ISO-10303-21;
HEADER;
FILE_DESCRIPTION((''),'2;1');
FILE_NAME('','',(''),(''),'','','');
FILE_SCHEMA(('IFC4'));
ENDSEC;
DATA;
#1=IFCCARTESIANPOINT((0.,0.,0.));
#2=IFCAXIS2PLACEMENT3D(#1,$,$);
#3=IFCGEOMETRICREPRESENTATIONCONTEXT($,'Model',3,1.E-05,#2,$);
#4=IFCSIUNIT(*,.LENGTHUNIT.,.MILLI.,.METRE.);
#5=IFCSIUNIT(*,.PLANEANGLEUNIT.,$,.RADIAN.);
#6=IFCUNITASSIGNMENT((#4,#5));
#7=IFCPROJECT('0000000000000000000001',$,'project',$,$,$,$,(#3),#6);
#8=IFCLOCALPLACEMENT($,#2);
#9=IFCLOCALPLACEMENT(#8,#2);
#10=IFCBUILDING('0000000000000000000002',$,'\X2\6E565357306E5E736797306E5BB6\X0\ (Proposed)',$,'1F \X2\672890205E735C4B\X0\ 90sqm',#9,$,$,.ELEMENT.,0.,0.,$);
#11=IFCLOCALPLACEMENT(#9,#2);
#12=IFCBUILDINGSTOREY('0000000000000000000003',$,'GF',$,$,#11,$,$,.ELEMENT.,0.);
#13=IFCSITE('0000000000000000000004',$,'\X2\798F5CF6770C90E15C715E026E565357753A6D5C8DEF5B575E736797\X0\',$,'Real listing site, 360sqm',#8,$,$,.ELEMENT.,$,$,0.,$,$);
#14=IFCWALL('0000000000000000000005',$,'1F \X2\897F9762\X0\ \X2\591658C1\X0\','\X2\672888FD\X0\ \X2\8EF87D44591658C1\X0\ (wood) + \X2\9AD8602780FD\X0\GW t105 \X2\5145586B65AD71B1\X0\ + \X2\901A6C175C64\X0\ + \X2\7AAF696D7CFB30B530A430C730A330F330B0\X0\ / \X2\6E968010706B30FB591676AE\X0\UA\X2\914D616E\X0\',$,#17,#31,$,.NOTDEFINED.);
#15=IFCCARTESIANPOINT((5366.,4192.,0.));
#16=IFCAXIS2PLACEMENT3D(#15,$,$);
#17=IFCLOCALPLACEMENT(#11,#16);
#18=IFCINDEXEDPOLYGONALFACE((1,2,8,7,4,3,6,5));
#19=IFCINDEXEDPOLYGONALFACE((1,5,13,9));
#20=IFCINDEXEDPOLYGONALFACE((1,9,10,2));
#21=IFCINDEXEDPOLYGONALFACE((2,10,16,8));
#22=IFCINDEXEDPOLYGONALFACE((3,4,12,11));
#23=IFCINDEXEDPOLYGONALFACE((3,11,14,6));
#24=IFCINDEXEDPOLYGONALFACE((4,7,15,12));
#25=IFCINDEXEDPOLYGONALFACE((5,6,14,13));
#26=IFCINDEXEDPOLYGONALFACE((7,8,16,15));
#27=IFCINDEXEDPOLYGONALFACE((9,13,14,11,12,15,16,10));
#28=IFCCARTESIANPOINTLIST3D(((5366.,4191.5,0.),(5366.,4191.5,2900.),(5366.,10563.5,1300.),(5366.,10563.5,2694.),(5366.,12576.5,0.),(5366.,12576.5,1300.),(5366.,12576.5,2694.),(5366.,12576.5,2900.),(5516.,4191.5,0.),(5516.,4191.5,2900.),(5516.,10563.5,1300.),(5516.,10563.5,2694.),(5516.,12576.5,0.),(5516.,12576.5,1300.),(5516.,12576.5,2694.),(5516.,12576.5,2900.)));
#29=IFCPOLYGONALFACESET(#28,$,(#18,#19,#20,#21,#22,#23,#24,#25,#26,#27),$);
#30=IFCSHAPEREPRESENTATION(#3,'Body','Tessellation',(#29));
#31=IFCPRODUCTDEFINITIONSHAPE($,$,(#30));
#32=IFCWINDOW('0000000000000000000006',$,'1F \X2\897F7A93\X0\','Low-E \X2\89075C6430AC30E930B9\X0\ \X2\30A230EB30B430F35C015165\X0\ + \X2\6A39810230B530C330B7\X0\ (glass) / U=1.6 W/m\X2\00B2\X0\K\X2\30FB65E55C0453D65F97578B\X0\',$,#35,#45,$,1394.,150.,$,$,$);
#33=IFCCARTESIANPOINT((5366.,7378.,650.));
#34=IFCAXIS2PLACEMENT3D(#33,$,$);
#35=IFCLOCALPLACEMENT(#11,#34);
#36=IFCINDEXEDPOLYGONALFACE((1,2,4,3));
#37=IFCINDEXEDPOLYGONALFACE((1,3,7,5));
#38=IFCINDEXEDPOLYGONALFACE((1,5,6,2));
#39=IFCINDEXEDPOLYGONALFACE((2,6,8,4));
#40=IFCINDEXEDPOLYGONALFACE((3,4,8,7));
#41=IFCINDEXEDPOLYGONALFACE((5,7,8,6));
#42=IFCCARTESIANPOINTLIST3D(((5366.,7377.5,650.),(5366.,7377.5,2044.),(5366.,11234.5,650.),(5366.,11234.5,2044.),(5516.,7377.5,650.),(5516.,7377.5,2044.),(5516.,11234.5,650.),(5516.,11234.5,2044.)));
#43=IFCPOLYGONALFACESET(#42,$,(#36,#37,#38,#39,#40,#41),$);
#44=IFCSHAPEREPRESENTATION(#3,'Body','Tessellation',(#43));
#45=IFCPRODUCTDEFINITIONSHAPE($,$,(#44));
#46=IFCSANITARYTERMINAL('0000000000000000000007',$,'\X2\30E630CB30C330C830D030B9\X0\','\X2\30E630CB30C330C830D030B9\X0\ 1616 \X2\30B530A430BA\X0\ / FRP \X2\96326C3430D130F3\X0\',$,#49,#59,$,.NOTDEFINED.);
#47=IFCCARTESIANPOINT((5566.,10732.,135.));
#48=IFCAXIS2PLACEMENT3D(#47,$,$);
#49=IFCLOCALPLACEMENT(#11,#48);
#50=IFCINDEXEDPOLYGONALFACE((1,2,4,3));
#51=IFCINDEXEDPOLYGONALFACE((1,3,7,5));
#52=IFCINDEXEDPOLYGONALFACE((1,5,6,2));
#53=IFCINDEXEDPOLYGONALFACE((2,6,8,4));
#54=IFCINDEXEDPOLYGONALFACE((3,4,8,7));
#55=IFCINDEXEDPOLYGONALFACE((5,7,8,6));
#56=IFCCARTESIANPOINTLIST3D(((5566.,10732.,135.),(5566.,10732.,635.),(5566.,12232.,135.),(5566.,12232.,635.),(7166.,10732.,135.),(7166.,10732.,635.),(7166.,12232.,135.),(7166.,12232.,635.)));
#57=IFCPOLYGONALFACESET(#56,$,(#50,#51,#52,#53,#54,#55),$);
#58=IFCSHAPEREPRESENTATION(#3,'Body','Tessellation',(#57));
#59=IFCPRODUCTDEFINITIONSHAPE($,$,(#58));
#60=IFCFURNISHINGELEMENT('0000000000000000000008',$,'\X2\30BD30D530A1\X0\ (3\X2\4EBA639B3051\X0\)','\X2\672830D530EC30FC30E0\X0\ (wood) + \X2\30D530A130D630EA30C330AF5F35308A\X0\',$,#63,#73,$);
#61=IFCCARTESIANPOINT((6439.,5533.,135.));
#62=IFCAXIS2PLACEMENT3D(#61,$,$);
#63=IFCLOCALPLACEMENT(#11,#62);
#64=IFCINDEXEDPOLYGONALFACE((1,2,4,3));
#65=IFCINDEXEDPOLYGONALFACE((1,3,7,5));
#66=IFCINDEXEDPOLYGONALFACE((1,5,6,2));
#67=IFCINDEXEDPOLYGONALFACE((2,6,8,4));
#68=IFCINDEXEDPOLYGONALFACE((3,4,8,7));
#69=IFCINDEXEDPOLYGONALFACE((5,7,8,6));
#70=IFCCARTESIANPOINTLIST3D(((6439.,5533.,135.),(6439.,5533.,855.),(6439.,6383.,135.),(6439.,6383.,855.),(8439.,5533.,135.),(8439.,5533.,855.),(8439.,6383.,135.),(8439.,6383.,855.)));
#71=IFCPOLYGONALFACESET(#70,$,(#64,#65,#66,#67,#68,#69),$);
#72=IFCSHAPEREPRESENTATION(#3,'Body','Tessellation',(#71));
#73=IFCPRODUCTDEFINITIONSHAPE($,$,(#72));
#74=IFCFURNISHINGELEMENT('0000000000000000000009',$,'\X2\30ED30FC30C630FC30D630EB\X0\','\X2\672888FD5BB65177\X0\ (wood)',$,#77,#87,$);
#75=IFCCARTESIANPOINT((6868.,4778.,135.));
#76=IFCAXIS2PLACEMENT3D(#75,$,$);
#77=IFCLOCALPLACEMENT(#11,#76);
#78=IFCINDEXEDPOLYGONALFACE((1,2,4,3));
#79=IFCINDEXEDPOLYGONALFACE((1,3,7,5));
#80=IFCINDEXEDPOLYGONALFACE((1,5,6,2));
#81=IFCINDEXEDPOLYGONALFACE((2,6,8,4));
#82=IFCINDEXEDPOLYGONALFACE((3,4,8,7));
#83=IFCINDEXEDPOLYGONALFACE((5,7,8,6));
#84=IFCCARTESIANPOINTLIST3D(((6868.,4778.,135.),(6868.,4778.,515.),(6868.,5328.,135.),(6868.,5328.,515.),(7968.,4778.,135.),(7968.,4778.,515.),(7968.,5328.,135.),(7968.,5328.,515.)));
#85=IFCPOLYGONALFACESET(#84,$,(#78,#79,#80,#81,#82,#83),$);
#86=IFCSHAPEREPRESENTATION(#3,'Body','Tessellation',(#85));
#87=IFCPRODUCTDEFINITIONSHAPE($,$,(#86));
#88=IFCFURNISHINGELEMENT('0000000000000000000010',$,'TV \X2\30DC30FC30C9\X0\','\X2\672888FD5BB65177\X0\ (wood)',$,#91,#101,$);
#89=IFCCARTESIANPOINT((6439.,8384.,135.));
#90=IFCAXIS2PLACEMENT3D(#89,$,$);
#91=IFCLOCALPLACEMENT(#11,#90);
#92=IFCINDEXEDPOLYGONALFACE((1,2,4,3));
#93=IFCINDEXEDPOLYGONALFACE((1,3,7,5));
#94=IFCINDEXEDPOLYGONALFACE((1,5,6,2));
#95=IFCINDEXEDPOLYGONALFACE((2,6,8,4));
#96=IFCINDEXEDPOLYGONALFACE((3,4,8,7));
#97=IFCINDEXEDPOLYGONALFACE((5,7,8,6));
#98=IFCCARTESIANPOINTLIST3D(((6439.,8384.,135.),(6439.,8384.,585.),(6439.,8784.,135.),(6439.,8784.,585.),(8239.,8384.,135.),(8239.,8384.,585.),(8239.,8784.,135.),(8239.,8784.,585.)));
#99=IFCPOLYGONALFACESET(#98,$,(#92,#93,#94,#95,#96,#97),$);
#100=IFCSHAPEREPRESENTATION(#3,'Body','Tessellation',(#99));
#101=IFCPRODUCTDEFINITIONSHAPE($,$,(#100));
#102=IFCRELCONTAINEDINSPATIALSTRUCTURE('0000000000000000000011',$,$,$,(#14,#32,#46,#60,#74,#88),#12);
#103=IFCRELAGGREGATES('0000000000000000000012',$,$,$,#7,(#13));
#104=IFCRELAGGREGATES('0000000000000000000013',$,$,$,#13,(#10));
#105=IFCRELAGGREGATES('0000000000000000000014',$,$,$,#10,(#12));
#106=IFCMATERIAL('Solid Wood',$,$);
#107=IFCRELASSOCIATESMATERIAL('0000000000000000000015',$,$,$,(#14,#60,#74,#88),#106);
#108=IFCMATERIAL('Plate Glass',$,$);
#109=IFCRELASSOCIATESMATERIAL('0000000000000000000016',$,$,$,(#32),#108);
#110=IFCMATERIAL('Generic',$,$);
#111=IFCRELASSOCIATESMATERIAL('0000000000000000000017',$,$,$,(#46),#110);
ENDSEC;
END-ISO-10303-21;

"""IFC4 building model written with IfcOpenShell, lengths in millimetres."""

from ifc_helpers import new_model, si_unit, frame, frame_2d, origin, place, context, project, spatial, rectangle, extrude, material, element, fill, save


model = new_model("IFC4")

# Units and contexts
model_context = context("Model", 3, precision=1e-05, world=origin())
ifc_project = project(units=[si_unit("LENGTHUNIT", "METRE", prefix="MILLI"), si_unit("PLANEANGLEUNIT", "RADIAN")], contexts=[model_context])

# Site, building, storey
site_placement = place(None, origin())
site = spatial("IfcSite", under=ifc_project, at=site_placement, Name="福島県郡山市湖南町浜路字平林", ObjectType="Real listing site, 360sqm", CompositionType="ELEMENT", RefElevation=0.0)
building_placement = place(site_placement, origin())
building = spatial("IfcBuilding", under=site, at=building_placement, Name="湖南の平林の家 (Proposed)", ObjectType="1F 木造平屋 90sqm", CompositionType="ELEMENT", ElevationOfRefHeight=0.0, ElevationOfTerrain=0.0)
storey_placement = place(building_placement, origin())
storey = spatial("IfcBuildingStorey", under=building, at=storey_placement, Name="GF", CompositionType="ELEMENT", Elevation=0.0)

# Shared definitions
ifc_material_1 = material(Name="Solid Wood")

# Shared definitions
ifc_material_2 = material(Name="Plate Glass")

# Wall, opening, window
wall_1_placement = place(storey_placement, frame((5366.0, 4192.0, 0.0)))
wall_1 = element("IfcWall", 1, at=wall_1_placement, inside=storey, material=ifc_material_1, Name="1F 西面 外壁", Description="木製 軸組外壁 (wood) + 高性能GW t105 充填断熱 + 通気層 + 窯業系サイディング / 準耐火・外皮UA配慮", PredefinedType="NOTDEFINED", context=model_context, shape_type="SweptSolid", body=[
    extrude(rectangle(XDim=150.0, YDim=8385.0, at=frame_2d((75.0, 4192.0))), frame((5366.0, 4192.0, 0.0)), (0.0, 0.0, 1.0), 2900.0),
])
opening_1_placement = place(storey_placement, frame((5366.0, 7378.0, 650.0)))
opening_1 = element("IfcOpeningElement", 2, at=opening_1_placement, cuts=wall_1, PredefinedType="NOTDEFINED", context=model_context, shape_type="SweptSolid", body=[
    extrude(rectangle(XDim=150.0, YDim=3857.0, at=frame_2d((75.0, 1928.0))), frame((5366.0, 7378.0, 650.0)), (0.0, 0.0, 1.0), 1394.0),
])
window_1_placement = place(storey_placement, frame((5366.0, 7378.0, 650.0)))
window_1 = element("IfcWindow", 3, at=window_1_placement, inside=storey, material=ifc_material_2, Name="1F 西窓", Description="Low-E 複層ガラス アルゴン封入 + 樹脂サッシ (glass) / U=1.6 W/m²K・日射取得型", OverallHeight=1394.0, OverallWidth=150.0, context=model_context, shape_type="SweptSolid", body=[
    extrude(rectangle(XDim=150.0, YDim=3857.0, at=frame_2d((75.0, 1928.0))), frame((5366.0, 7378.0, 650.0)), (0.0, 0.0, 1.0), 1394.0),
])
fill(opening_1, window_1)

# Shared definitions
ifc_material_3 = material(Name="Generic")

# Sanitary terminal
sanitary_terminal_placement = place(storey_placement, frame((5566.0, 10732.0, 135.0)))
element("IfcSanitaryTerminal", 4, at=sanitary_terminal_placement, inside=storey, material=ifc_material_3, Name="ユニットバス", Description="ユニットバス 1616 サイズ / FRP 防水パン", PredefinedType="NOTDEFINED", context=model_context, shape_type="SweptSolid", body=[
    extrude(rectangle(XDim=1600.0, YDim=1500.0, at=frame_2d((800.0, 750.0))), frame((5566.0, 10732.0, 135.0)), (0.0, 0.0, 1.0), 500.0),
])

# Furnishing elements
furnishing_1_placement = place(storey_placement, frame((6439.0, 5533.0, 135.0)))
element("IfcFurnishingElement", 5, at=furnishing_1_placement, inside=storey, material=ifc_material_1, Name="ソファ (3人掛け)", Description="木フレーム (wood) + ファブリック張り", context=model_context, shape_type="SweptSolid", body=[
    extrude(rectangle(XDim=2000.0, YDim=850.0, at=frame_2d((1000.0, 425.0))), frame((6439.0, 5533.0, 135.0)), (0.0, 0.0, 1.0), 720.0),
])
furnishing_2_placement = place(storey_placement, frame((6868.0, 4778.0, 135.0)))
element("IfcFurnishingElement", 6, at=furnishing_2_placement, inside=storey, material=ifc_material_1, Name="ローテーブル", Description="木製家具 (wood)", context=model_context, shape_type="SweptSolid", body=[
    extrude(rectangle(XDim=1100.0, YDim=550.0, at=frame_2d((550.0, 275.0))), frame((6868.0, 4778.0, 135.0)), (0.0, 0.0, 1.0), 380.0),
])
furnishing_3_placement = place(storey_placement, frame((6439.0, 8384.0, 135.0)))
element("IfcFurnishingElement", 7, at=furnishing_3_placement, inside=storey, material=ifc_material_1, Name="TV ボード", Description="木製家具 (wood)", context=model_context, shape_type="SweptSolid", body=[
    extrude(rectangle(XDim=1800.0, YDim=400.0, at=frame_2d((900.0, 200.0))), frame((6439.0, 8384.0, 135.0)), (0.0, 0.0, 1.0), 450.0),
])

save(model, "model.ifc")
